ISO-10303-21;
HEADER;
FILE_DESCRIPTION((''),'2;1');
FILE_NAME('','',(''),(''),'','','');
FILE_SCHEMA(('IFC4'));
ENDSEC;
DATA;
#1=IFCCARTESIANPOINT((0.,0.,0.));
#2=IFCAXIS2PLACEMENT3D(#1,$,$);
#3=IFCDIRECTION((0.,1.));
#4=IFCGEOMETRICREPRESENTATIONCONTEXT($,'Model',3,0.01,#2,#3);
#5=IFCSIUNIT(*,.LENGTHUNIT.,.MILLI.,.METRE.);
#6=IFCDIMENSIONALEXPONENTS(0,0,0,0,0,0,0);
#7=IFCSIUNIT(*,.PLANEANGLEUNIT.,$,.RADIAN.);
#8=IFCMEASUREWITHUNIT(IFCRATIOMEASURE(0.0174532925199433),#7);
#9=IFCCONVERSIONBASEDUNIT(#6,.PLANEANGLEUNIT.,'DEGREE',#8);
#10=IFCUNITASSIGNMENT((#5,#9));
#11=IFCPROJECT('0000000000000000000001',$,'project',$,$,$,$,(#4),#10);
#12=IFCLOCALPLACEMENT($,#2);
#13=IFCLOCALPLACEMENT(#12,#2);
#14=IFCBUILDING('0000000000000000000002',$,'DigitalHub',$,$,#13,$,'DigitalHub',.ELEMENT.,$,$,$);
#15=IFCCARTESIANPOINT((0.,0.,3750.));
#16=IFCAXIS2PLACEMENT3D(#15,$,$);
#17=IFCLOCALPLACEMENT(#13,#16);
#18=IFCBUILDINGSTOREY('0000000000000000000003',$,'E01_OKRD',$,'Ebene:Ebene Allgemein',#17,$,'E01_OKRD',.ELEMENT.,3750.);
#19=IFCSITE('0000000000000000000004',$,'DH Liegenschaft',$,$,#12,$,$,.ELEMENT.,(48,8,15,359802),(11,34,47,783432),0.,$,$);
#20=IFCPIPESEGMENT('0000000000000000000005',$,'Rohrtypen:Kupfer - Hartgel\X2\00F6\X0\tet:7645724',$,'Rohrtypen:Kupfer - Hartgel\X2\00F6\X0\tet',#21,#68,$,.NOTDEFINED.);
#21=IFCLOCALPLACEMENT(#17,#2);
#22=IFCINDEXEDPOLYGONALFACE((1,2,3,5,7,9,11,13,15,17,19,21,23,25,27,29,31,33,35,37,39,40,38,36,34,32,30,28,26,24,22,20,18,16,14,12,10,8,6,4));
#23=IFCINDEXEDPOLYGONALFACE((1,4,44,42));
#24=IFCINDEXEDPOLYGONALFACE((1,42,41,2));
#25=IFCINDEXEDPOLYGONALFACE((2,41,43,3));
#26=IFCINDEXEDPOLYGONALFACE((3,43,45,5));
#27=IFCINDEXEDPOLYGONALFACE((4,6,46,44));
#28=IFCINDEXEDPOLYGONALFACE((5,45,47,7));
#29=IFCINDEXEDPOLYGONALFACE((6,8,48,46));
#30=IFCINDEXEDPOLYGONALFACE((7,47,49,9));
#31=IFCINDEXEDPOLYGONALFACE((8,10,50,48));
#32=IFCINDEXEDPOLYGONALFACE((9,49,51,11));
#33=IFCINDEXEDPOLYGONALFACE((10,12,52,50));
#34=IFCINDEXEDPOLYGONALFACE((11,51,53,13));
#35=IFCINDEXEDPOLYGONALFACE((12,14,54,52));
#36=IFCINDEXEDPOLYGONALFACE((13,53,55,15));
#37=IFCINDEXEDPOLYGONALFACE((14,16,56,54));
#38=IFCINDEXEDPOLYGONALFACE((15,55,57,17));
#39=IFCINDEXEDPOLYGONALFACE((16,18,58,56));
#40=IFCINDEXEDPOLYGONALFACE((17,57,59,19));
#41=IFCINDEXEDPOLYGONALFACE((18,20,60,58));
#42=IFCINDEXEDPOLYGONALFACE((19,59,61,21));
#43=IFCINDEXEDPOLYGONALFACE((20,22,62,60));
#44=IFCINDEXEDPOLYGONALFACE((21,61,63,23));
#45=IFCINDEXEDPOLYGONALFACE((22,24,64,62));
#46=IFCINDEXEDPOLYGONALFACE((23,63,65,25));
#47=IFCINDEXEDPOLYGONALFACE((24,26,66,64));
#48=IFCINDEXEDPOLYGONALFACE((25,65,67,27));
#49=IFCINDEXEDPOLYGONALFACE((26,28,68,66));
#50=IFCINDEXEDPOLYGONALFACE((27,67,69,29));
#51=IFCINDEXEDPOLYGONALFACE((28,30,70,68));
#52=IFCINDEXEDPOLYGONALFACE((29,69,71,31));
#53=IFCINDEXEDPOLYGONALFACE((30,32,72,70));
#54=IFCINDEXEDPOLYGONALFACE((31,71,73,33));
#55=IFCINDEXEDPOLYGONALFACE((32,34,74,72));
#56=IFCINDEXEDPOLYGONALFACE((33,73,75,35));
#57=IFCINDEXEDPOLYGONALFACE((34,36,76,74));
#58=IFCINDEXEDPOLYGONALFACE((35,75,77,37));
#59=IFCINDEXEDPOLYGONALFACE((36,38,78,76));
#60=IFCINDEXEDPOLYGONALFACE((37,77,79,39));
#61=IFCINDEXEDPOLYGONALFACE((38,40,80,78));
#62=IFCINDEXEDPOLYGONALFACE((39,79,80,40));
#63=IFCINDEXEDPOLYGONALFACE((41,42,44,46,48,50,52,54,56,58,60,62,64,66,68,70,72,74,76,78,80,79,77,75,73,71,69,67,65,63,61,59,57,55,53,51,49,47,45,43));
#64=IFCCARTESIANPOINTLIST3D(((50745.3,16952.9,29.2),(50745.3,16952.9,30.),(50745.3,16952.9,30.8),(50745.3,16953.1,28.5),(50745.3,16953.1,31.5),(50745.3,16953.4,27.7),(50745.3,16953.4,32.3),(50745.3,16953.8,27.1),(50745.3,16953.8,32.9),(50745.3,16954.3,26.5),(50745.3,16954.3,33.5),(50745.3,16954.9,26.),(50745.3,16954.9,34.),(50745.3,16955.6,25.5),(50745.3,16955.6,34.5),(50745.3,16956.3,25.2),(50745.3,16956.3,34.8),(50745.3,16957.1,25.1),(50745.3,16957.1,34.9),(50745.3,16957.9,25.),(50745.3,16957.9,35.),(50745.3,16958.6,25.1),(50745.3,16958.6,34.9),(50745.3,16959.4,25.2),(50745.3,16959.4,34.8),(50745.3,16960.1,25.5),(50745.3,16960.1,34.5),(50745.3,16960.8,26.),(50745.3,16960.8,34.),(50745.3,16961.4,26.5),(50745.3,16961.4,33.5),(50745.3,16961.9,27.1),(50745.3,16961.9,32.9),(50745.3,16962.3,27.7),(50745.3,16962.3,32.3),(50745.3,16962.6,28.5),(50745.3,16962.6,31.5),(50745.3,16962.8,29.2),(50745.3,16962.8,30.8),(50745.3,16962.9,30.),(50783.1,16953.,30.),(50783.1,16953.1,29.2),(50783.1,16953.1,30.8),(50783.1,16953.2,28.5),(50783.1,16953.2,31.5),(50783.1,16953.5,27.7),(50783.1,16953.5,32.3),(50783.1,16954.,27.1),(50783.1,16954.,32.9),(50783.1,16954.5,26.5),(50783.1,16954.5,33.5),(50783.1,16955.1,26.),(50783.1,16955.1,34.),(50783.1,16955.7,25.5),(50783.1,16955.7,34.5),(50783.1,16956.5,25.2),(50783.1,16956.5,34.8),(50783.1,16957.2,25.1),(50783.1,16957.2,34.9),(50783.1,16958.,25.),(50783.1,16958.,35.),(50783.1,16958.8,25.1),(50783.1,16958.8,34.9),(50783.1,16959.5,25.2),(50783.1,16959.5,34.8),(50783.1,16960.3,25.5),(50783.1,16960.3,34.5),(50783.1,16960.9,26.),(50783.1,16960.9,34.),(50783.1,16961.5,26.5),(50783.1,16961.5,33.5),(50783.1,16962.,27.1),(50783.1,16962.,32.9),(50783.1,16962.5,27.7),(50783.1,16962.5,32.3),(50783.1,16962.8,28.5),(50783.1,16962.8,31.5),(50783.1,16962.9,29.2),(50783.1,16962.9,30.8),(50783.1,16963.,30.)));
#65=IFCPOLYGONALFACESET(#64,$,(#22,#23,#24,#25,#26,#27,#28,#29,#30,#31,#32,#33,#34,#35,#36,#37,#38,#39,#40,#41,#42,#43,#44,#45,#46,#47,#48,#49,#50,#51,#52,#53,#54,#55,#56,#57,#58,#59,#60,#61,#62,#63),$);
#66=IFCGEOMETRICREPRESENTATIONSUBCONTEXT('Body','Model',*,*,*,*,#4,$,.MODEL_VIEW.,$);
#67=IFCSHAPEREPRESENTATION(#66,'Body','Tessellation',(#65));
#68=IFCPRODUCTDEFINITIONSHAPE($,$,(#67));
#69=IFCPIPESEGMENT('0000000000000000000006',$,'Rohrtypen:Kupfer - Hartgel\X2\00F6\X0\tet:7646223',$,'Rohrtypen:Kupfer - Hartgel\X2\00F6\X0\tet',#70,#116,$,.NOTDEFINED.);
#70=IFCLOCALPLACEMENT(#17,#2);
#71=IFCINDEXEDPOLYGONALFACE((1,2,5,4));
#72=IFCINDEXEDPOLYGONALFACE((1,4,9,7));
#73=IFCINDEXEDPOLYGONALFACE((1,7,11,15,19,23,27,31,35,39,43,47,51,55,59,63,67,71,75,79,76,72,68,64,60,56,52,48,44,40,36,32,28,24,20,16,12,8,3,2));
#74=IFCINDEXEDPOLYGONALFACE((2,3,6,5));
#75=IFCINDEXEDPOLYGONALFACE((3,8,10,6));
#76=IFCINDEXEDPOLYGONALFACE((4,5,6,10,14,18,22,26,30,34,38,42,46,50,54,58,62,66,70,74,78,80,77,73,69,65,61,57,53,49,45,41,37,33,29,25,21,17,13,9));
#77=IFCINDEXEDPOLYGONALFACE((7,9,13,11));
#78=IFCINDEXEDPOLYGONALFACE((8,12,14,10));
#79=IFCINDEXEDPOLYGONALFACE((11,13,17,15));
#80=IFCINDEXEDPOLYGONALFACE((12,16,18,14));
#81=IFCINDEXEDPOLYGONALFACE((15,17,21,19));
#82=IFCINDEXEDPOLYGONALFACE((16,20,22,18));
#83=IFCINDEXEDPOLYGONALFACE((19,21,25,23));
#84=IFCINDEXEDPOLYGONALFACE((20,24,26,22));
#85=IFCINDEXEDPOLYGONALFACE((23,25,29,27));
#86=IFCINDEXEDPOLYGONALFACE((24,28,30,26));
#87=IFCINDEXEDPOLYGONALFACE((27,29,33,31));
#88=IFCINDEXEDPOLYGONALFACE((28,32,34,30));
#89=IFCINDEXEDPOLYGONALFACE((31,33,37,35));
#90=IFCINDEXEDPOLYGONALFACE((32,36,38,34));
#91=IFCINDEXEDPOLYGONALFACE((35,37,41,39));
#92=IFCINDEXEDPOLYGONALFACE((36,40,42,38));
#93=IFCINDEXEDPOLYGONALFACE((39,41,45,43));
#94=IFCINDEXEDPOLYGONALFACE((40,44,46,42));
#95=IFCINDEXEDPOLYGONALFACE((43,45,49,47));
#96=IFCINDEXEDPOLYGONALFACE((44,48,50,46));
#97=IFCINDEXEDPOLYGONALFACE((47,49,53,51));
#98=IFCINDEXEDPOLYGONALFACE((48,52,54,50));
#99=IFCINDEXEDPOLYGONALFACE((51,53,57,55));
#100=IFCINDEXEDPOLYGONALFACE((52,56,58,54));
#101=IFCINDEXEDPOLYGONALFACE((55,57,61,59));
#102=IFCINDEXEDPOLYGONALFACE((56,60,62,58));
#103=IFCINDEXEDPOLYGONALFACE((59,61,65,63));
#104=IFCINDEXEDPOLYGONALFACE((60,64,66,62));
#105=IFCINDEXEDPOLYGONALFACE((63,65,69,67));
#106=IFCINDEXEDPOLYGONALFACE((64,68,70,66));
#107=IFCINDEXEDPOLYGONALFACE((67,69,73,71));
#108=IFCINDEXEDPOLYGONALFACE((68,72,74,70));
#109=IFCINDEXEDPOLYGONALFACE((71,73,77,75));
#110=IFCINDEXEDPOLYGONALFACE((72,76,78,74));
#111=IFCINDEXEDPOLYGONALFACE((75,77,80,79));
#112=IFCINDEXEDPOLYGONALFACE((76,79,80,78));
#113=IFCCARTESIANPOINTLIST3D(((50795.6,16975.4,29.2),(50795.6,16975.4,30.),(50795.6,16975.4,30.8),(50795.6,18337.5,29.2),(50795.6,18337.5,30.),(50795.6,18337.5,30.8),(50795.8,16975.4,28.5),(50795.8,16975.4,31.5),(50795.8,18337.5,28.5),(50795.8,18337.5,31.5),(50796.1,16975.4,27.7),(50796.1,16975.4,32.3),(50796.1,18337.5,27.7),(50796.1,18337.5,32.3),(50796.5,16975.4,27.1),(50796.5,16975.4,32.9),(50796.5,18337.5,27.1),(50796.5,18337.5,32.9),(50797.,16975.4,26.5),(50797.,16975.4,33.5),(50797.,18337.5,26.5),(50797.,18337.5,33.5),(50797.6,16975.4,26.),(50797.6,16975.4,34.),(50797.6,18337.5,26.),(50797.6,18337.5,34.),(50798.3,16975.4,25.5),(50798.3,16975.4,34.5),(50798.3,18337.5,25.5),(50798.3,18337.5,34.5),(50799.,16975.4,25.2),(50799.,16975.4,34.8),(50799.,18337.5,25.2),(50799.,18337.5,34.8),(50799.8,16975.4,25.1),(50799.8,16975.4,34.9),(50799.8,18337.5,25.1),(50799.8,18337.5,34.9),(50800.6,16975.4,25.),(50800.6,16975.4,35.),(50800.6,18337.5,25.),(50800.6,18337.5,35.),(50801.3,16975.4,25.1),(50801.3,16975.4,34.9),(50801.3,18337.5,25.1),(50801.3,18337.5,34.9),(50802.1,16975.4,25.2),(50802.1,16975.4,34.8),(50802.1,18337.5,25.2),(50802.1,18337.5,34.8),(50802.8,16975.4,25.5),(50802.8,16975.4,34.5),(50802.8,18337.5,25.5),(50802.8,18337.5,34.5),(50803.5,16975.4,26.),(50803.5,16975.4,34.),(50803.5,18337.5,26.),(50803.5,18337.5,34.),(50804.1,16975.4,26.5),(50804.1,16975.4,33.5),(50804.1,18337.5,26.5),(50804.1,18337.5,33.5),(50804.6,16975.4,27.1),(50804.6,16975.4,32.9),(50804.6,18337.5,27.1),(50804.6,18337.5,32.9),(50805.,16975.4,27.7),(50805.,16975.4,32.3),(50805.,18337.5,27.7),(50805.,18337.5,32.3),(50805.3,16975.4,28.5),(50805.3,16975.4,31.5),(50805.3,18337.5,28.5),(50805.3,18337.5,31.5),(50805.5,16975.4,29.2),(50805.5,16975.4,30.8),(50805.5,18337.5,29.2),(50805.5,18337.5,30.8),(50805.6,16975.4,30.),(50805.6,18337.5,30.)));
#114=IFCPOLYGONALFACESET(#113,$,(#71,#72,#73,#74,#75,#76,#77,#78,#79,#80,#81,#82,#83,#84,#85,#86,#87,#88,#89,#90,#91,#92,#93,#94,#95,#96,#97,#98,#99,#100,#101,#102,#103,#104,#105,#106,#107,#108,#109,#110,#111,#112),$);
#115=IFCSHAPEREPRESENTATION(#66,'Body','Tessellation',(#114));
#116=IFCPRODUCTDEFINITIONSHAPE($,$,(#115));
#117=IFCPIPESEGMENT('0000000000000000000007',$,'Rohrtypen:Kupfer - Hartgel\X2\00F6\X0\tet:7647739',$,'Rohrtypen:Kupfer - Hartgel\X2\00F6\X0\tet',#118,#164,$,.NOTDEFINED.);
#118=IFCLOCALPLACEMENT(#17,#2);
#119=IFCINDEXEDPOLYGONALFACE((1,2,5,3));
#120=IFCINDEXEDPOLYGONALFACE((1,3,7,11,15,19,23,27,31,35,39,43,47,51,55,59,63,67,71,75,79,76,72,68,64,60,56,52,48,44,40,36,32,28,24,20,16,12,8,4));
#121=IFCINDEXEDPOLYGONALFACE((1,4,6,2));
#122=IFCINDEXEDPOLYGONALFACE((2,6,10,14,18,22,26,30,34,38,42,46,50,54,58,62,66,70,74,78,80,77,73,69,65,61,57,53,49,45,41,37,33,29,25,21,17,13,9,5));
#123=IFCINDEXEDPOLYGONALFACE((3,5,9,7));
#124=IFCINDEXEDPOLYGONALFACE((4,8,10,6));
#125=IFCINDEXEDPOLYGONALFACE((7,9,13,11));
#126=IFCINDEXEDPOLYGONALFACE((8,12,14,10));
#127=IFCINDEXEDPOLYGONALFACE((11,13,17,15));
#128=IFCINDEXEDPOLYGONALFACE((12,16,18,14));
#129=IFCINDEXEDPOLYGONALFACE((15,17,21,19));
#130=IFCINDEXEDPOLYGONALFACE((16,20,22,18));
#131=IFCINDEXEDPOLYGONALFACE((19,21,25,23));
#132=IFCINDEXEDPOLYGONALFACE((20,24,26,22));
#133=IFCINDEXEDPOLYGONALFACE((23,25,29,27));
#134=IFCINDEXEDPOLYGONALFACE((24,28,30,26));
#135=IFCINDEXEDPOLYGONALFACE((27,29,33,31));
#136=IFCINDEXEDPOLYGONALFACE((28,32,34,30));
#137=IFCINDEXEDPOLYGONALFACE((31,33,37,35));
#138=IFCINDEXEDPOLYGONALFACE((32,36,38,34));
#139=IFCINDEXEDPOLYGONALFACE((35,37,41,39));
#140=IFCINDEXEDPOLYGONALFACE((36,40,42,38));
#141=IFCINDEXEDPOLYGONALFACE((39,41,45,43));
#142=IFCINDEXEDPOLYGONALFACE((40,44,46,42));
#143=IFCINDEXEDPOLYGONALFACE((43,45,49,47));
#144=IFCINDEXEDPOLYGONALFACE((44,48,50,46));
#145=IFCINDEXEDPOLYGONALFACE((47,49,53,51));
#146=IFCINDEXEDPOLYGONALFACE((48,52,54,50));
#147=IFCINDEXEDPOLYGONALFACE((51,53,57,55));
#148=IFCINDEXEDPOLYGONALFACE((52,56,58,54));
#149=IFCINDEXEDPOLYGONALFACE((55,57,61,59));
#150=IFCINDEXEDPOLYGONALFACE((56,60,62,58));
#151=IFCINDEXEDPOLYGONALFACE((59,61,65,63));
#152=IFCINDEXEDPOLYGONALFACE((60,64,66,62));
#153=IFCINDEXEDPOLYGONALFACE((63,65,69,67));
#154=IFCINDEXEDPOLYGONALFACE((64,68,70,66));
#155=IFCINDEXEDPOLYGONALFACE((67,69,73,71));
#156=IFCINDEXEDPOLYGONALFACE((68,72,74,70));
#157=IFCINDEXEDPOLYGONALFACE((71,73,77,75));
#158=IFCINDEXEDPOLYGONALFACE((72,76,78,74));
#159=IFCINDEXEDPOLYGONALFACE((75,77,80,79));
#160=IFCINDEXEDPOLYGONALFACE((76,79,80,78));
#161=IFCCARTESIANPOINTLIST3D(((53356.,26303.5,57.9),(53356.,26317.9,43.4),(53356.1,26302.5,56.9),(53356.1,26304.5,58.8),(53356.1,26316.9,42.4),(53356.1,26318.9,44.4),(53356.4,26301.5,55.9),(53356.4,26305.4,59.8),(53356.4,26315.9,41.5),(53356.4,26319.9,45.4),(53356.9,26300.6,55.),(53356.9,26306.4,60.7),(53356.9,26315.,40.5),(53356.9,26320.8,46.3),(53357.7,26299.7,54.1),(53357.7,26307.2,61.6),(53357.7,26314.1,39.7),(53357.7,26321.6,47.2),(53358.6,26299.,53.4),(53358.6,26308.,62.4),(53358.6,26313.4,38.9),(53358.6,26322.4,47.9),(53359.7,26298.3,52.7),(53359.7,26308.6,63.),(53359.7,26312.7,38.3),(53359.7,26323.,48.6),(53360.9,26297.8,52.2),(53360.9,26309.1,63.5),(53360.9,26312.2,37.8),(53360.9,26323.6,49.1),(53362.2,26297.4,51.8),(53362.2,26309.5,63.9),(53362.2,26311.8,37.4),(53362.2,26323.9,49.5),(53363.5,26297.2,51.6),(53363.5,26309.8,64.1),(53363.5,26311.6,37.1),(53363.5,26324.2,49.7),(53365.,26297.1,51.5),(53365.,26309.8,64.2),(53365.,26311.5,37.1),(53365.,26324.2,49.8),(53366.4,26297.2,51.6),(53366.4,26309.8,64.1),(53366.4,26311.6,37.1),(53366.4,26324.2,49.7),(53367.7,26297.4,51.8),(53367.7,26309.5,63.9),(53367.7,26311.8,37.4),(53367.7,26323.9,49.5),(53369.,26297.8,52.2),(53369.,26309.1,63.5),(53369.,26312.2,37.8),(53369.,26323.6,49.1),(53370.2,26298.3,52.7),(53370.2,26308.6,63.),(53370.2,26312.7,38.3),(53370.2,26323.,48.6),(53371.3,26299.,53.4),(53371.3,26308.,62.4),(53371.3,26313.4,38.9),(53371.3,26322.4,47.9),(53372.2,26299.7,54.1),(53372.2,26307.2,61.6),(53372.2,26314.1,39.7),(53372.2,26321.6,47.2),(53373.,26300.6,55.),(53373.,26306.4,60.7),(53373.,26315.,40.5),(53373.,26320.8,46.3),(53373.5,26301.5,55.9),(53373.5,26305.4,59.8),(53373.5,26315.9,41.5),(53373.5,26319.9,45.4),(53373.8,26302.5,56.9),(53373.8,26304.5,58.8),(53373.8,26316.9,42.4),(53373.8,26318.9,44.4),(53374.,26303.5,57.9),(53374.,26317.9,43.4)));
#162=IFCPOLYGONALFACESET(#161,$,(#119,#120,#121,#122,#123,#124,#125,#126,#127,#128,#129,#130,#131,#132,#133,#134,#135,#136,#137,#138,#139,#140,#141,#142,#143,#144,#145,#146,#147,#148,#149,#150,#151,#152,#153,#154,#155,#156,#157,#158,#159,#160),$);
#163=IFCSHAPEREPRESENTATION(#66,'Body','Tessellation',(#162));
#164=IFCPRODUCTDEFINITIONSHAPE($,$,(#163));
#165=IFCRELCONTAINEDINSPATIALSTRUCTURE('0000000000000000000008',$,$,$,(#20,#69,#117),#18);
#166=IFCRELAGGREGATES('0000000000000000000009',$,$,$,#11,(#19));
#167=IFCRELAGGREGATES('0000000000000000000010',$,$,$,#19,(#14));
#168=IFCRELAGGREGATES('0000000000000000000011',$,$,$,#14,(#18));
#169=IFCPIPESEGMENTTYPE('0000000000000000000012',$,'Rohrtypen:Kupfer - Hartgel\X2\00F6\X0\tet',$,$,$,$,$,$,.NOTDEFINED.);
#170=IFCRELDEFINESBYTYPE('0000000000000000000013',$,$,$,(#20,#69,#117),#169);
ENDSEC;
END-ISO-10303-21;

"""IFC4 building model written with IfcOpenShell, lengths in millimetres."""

from ifc_helpers import new_model, entity, si_unit, converted_unit, direction, frame, origin, place, context, subcontext, project, spatial, indexed_curve, outline, extrude, type_object, element, save


model = new_model("IFC4")

# Units and contexts
model_context = context("Model", 3, precision=0.01, world=origin(), true_north=direction((0.0, 1.0)))
body_context = subcontext(model_context, "Body", "Model", "MODEL_VIEW")
ifc_project = project(units=[si_unit("LENGTHUNIT", "METRE", prefix="MILLI"), converted_unit("PLANEANGLEUNIT", "DEGREE", entity("IfcRatioMeasure", 0.0174532925199433), si_unit("PLANEANGLEUNIT", "RADIAN"), dimensions=[0, 0, 0, 0, 0, 0, 0])], contexts=[model_context])

# Site, building, storey
site_placement = place(None, origin())
site = spatial("IfcSite", under=ifc_project, at=site_placement, Name="DH Liegenschaft", CompositionType="ELEMENT", RefLatitude=(48, 8, 15, 359802), RefLongitude=(11, 34, 47, 783432), RefElevation=0.0)
building_placement = place(site_placement, origin())
building = spatial("IfcBuilding", under=site, at=building_placement, Name="DigitalHub", LongName="DigitalHub", CompositionType="ELEMENT")
storey_placement = place(building_placement, frame((0.0, 0.0, 3750.0)))
storey = spatial("IfcBuildingStorey", under=building, at=storey_placement, Name="E01_OKRD", ObjectType="Ebene:Ebene Allgemein", LongName="E01_OKRD", CompositionType="ELEMENT", Elevation=3750.0)

# Pipe segments
pipe_segment_type = type_object("IfcPipeSegmentType", Name="Rohrtypen:Kupfer - Hartgelötet", PredefinedType="NOTDEFINED")
pipe_segment_1_placement = place(storey_placement, frame((50745.3, 16951.3, 23.4)))
element("IfcPipeSegment", 1, at=pipe_segment_1_placement, inside=storey, type_object=pipe_segment_type, Name="Rohrtypen:Kupfer - Hartgelötet:7645724", ObjectType="Rohrtypen:Kupfer - Hartgelötet", PredefinedType="NOTDEFINED", context=body_context, shape_type="SweptSolid", body=[
    extrude(outline(indexed_curve([(5.0, 0.0), (4.9, 0.8), (4.8, 1.5), (4.5, 2.3), (4.0, 2.9), (3.5, 3.5), (2.9, 4.0), (2.3, 4.5), (1.5, 4.8), (0.8, 4.9), (0.0, 5.0), (-0.8, 4.9), (-1.5, 4.8), (-2.3, 4.5), (-2.9, 4.0), (-3.5, 3.5), (-4.0, 2.9), (-4.5, 2.3), (-4.8, 1.5), (-4.9, 0.8), (-5.0, 0.0), (-4.9, -0.8), (-4.8, -1.5), (-4.5, -2.3), (-4.0, -2.9), (-3.5, -3.5), (-2.9, -4.0), (-2.3, -4.5), (-1.5, -4.8), (-0.8, -4.9), (0.0, -5.0), (0.8, -4.9), (1.5, -4.8), (2.3, -4.5), (2.9, -4.0), (3.5, -3.5), (4.0, -2.9), (4.5, -2.3), (4.8, -1.5), (4.9, -0.8), (5.0, 0.0)], self_intersect=False)), frame((0.0, 6.6, 6.6), z_axis=(0.999993, 0.003679, 0.0), x_axis=(0.003679, -0.999993, 0.0)), (0.0, 0.0, 1.0), 37.8),
])
pipe_segment_2_placement = place(storey_placement, frame((50794.0, 16975.4, 23.4)))
element("IfcPipeSegment", 2, at=pipe_segment_2_placement, inside=storey, type_object=pipe_segment_type, Name="Rohrtypen:Kupfer - Hartgelötet:7646223", ObjectType="Rohrtypen:Kupfer - Hartgelötet", PredefinedType="NOTDEFINED", context=body_context, shape_type="SweptSolid", body=[
    extrude(outline(indexed_curve([(5.0, 0.0), (4.9, 0.8), (4.8, 1.5), (4.5, 2.3), (4.0, 2.9), (3.5, 3.5), (2.9, 4.0), (2.3, 4.5), (1.5, 4.8), (0.8, 4.9), (0.0, 5.0), (-0.8, 4.9), (-1.5, 4.8), (-2.3, 4.5), (-2.9, 4.0), (-3.5, 3.5), (-4.0, 2.9), (-4.5, 2.3), (-4.8, 1.5), (-4.9, 0.8), (-5.0, 0.0), (-4.9, -0.8), (-4.8, -1.5), (-4.5, -2.3), (-4.0, -2.9), (-3.5, -3.5), (-2.9, -4.0), (-2.3, -4.5), (-1.5, -4.8), (-0.8, -4.9), (0.0, -5.0), (0.8, -4.9), (1.5, -4.8), (2.3, -4.5), (2.9, -4.0), (3.5, -3.5), (4.0, -2.9), (4.5, -2.3), (4.8, -1.5), (4.9, -0.8), (5.0, 0.0)], self_intersect=False)), frame((6.6, 0.0, 6.6), z_axis=(0.0, 1.0, 0.0), x_axis=(-1.0, 0.0, 0.0)), (0.0, 0.0, 1.0), 1362.1),
])
pipe_segment_3_placement = place(storey_placement, frame((53354.4, 26295.5, 35.5)))
element("IfcPipeSegment", 3, at=pipe_segment_3_placement, inside=storey, type_object=pipe_segment_type, Name="Rohrtypen:Kupfer - Hartgelötet:7647739", ObjectType="Rohrtypen:Kupfer - Hartgelötet", PredefinedType="NOTDEFINED", context=body_context, shape_type="SweptSolid", body=[
    extrude(outline(indexed_curve([(9.0, 0.0), (8.9, 1.4), (8.6, 2.8), (8.0, 4.1), (7.3, 5.3), (6.4, 6.4), (5.3, 7.3), (4.1, 8.0), (2.8, 8.6), (1.4, 8.9), (0.0, 9.0), (-1.4, 8.9), (-2.8, 8.6), (-4.1, 8.0), (-5.3, 7.3), (-6.4, 6.4), (-7.3, 5.3), (-8.0, 4.1), (-8.6, 2.8), (-8.9, 1.4), (-9.0, 0.0), (-8.9, -1.4), (-8.6, -2.8), (-8.0, -4.1), (-7.3, -5.3), (-6.4, -6.4), (-5.3, -7.3), (-4.1, -8.0), (-2.8, -8.6), (-1.4, -8.9), (0.0, -9.0), (1.4, -8.9), (2.8, -8.6), (4.1, -8.0), (5.3, -7.3), (6.4, -6.4), (7.3, -5.3), (8.0, -4.1), (8.6, -2.8), (8.9, -1.4), (9.0, 0.0)], self_intersect=False)), frame((10.6, 22.4, 8.0), z_axis=(0.0, -0.707107, 0.707107), x_axis=(-1.0, 0.0, 0.0)), (0.0, 0.0, 1.0), 20.4),
])

save(model, "model.ifc")
